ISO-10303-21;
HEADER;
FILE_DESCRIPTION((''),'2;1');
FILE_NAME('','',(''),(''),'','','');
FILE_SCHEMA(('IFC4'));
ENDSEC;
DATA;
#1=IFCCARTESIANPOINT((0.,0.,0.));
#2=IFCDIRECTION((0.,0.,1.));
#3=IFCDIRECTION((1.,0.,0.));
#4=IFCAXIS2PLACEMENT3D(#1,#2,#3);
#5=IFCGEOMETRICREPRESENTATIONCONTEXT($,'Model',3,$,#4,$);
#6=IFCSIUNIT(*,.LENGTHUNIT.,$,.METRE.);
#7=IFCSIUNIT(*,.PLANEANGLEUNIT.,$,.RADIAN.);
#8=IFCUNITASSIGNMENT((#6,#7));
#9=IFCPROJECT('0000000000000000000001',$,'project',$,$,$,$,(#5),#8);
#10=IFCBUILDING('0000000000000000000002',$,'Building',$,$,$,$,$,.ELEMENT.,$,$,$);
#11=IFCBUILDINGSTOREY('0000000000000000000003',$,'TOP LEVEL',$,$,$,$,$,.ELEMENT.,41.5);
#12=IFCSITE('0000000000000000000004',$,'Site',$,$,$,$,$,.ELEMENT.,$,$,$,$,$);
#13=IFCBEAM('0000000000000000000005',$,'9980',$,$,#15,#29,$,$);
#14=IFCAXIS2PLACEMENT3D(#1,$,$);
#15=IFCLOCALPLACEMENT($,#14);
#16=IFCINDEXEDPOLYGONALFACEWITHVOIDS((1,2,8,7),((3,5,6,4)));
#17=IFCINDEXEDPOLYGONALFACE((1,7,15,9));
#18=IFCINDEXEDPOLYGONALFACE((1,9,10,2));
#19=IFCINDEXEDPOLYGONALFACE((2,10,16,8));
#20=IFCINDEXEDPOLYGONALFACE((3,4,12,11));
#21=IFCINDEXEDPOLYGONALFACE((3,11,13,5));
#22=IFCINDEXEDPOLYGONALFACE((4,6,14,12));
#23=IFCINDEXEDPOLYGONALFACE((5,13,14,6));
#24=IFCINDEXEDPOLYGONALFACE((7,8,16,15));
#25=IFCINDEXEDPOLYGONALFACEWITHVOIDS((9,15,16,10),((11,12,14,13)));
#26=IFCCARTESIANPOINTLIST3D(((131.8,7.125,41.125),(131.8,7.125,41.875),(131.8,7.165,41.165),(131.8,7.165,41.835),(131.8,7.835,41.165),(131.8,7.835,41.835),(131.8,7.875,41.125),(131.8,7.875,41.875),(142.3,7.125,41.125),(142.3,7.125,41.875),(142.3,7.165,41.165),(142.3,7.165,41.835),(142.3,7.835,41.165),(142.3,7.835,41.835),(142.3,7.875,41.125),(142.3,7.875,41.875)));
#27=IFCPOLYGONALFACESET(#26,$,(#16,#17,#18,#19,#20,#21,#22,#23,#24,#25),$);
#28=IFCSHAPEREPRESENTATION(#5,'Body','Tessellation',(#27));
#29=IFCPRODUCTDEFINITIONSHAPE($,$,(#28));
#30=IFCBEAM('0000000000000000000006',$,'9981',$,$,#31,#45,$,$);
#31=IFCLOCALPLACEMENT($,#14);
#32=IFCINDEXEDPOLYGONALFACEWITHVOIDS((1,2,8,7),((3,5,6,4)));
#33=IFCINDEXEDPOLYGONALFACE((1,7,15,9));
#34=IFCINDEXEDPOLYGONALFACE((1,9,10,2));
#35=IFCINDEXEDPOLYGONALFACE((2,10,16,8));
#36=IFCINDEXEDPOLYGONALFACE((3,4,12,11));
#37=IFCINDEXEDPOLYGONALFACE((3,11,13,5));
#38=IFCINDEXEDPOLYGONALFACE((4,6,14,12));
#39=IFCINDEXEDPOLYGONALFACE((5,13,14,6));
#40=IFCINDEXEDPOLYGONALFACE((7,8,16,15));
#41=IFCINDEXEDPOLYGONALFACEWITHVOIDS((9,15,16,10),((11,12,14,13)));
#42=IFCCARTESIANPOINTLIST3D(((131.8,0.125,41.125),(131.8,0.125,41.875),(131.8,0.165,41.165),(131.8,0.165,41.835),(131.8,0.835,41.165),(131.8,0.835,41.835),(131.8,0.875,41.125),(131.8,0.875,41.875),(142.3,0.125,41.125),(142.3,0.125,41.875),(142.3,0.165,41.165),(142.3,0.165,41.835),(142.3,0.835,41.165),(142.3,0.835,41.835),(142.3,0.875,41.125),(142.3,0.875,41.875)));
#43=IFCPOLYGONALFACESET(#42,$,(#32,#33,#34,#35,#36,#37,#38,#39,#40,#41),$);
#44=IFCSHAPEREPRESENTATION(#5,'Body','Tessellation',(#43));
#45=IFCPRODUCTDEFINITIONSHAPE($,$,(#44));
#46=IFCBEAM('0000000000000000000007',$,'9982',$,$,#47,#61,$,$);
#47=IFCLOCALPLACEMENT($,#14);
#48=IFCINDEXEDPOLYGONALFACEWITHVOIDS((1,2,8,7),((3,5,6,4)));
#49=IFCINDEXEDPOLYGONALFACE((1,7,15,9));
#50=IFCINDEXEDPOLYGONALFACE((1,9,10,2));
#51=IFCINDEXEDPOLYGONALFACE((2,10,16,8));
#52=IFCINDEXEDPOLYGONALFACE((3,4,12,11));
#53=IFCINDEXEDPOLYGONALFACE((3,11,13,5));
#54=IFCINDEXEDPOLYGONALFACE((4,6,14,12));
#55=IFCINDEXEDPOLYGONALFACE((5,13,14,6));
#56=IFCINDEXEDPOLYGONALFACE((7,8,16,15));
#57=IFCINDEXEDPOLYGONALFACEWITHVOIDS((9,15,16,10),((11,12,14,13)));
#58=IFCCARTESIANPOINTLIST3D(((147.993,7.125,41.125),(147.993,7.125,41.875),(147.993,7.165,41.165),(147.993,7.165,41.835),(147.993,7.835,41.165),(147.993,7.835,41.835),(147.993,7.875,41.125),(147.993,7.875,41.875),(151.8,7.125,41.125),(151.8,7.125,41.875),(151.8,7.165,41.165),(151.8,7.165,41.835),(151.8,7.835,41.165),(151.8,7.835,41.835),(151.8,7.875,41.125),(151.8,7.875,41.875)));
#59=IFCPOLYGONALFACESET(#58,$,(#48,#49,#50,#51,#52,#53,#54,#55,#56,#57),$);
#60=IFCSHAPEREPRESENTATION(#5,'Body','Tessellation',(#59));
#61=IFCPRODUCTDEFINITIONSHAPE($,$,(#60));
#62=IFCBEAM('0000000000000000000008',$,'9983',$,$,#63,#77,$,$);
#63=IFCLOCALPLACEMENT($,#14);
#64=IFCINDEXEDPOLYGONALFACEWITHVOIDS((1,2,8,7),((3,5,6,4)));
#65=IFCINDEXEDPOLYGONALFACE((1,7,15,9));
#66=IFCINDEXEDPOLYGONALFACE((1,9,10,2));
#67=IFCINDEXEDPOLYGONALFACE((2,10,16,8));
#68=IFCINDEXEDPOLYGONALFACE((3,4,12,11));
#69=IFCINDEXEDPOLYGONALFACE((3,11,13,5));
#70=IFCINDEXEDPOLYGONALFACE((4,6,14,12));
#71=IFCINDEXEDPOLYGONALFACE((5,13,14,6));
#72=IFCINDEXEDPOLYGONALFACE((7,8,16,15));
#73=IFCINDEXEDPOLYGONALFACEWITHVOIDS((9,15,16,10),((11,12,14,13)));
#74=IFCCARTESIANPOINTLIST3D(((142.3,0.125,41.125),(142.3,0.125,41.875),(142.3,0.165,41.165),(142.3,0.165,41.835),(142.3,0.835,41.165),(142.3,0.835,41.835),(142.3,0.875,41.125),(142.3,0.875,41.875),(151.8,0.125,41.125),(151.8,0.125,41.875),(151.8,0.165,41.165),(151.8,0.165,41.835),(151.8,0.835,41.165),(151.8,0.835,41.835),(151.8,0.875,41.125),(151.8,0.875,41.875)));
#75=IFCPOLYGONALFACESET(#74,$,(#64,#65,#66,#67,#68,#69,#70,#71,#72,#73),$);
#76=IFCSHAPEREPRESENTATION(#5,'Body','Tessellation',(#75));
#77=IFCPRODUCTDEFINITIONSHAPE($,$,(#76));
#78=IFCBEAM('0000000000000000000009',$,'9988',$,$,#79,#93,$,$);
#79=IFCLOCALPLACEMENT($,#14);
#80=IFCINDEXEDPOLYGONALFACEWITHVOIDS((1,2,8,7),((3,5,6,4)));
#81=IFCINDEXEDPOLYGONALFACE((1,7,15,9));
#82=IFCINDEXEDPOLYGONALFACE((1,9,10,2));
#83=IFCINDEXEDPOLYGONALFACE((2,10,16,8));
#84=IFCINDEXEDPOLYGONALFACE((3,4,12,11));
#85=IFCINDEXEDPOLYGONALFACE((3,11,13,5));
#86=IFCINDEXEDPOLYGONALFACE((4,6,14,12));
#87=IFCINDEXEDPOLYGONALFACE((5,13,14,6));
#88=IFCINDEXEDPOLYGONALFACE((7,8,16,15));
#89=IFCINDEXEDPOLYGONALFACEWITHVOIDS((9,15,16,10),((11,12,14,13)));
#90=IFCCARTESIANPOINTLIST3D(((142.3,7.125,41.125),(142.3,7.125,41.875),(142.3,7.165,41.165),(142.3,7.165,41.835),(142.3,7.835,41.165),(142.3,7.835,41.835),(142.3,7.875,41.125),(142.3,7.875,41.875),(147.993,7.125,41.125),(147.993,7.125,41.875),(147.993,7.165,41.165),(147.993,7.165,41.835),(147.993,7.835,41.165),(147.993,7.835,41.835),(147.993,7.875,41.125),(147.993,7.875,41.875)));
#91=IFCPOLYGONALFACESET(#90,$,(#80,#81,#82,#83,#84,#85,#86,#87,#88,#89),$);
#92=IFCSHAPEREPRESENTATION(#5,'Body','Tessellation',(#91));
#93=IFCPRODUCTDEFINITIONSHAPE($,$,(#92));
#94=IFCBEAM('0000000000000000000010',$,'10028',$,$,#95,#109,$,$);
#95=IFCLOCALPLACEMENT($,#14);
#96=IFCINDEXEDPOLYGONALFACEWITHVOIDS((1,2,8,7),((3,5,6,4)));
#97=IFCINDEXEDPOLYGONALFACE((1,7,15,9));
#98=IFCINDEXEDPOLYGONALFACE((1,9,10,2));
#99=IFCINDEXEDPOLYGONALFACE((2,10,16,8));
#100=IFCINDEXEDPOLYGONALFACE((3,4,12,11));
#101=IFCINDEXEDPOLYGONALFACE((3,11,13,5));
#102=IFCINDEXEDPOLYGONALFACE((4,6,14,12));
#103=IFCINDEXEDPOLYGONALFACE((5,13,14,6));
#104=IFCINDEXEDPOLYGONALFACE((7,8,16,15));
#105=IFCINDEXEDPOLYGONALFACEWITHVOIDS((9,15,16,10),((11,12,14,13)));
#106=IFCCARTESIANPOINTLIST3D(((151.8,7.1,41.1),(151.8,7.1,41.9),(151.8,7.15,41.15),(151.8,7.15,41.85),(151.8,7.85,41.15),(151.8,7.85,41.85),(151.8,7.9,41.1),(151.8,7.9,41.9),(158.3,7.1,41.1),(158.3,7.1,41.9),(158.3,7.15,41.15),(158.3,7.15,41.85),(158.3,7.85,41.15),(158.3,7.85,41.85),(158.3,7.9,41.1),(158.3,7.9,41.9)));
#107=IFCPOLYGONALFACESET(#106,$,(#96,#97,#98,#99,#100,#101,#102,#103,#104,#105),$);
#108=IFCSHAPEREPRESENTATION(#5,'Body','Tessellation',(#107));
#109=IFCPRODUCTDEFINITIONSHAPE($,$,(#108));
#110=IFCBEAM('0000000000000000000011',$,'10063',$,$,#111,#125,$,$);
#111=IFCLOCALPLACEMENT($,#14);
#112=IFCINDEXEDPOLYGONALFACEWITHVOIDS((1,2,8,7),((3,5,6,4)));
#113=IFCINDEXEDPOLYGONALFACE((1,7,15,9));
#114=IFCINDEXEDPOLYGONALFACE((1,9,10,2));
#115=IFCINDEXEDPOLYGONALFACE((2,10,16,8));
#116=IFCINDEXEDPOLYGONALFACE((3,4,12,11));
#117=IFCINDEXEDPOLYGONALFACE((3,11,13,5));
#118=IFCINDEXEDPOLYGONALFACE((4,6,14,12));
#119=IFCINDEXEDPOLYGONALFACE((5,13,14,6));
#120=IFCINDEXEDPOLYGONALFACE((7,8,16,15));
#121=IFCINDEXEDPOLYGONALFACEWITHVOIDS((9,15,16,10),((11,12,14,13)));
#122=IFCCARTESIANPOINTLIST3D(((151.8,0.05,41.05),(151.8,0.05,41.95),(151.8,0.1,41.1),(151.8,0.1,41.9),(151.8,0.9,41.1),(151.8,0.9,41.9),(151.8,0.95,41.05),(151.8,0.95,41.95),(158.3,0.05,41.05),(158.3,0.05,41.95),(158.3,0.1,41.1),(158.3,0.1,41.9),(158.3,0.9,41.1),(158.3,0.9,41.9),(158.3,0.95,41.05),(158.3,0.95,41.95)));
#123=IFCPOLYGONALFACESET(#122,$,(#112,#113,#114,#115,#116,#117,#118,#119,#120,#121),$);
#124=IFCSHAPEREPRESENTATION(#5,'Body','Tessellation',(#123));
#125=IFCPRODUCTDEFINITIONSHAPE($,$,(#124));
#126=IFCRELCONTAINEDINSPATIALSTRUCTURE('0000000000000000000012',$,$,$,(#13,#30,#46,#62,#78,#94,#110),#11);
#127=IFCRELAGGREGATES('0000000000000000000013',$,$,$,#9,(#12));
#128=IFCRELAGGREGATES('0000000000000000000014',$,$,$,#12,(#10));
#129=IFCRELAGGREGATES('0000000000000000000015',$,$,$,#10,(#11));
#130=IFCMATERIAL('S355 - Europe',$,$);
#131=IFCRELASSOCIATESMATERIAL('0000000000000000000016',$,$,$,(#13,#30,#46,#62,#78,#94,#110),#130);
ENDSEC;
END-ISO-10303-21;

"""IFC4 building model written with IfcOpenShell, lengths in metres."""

from ifc_helpers import new_model, si_unit, frame, origin_with_axes, origin_2d_with_axis, place, context, project, spatial, hollow_rectangle, extrude, material, material_profile, profile_set, profile_usage, element, save


model = new_model("IFC4")

# Units and contexts
model_context = context("Model", 3, world=origin_with_axes())
ifc_project = project(units=[si_unit("LENGTHUNIT", "METRE"), si_unit("PLANEANGLEUNIT", "RADIAN")], contexts=[model_context])

# Site, building, storey
site = spatial("IfcSite", under=ifc_project, Name="Site", CompositionType="ELEMENT")
building = spatial("IfcBuilding", under=site, Name="Building", CompositionType="ELEMENT")
storey = spatial("IfcBuildingStorey", under=building, Name="TOP LEVEL", CompositionType="ELEMENT", Elevation=41.5)

# Beams
ifc_material = material(Name="S355 - Europe")
ifc_material_profile_1 = material_profile(ifc_material, hollow_rectangle(XDim=0.75, YDim=0.75, WallThickness=0.04, at=origin_2d_with_axis()))
ifc_profile_set_1 = profile_set([ifc_material_profile_1])
ifc_profile_usage_1 = profile_usage(ifc_profile_set_1, cardinal=10)
beam_1_placement = place(None, frame((142.3, 7.5, 41.5), z_axis=(-1.0, 0.0, 0.0), x_axis=(0.0, -1.0, 0.0)))
element("IfcBeam", 1, at=beam_1_placement, inside=storey, material=ifc_profile_usage_1, Name="9980", context=model_context, shape_type="SweptSolid", body=[
    extrude(hollow_rectangle(XDim=0.75, YDim=0.75, WallThickness=0.04, at=origin_2d_with_axis()), origin_with_axes(), (0.0, 0.0, 1.0), 10.5),
])
ifc_material_profile_2 = material_profile(ifc_material, hollow_rectangle(XDim=0.75, YDim=0.75, WallThickness=0.04, at=origin_2d_with_axis()))
ifc_profile_set_2 = profile_set([ifc_material_profile_2])
ifc_profile_usage_2 = profile_usage(ifc_profile_set_2, cardinal=10)
beam_2_placement = place(None, frame((142.3, 0.5, 41.5), z_axis=(-1.0, 0.0, 0.0), x_axis=(0.0, -1.0, 0.0)))
element("IfcBeam", 2, at=beam_2_placement, inside=storey, material=ifc_profile_usage_2, Name="9981", context=model_context, shape_type="SweptSolid", body=[
    extrude(hollow_rectangle(XDim=0.75, YDim=0.75, WallThickness=0.04, at=origin_2d_with_axis()), origin_with_axes(), (0.0, 0.0, 1.0), 10.5),
])
ifc_material_profile_3 = material_profile(ifc_material, hollow_rectangle(XDim=0.75, YDim=0.75, WallThickness=0.04, at=origin_2d_with_axis()))
ifc_profile_set_3 = profile_set([ifc_material_profile_3])
ifc_profile_usage_3 = profile_usage(ifc_profile_set_3, cardinal=10)
beam_3_placement = place(None, frame((151.8, 7.5, 41.5), z_axis=(-1.0, 0.0, 0.0), x_axis=(0.0, -1.0, 0.0)))
element("IfcBeam", 3, at=beam_3_placement, inside=storey, material=ifc_profile_usage_3, Name="9982", context=model_context, shape_type="SweptSolid", body=[
    extrude(hollow_rectangle(XDim=0.75, YDim=0.75, WallThickness=0.04, at=origin_2d_with_axis()), origin_with_axes(), (0.0, 0.0, 1.0), 3.807),
])
ifc_material_profile_4 = material_profile(ifc_material, hollow_rectangle(XDim=0.75, YDim=0.75, WallThickness=0.04, at=origin_2d_with_axis()))
ifc_profile_set_4 = profile_set([ifc_material_profile_4])
ifc_profile_usage_4 = profile_usage(ifc_profile_set_4, cardinal=10)
beam_4_placement = place(None, frame((151.8, 0.5, 41.5), z_axis=(-1.0, 0.0, 0.0), x_axis=(0.0, -1.0, 0.0)))
element("IfcBeam", 4, at=beam_4_placement, inside=storey, material=ifc_profile_usage_4, Name="9983", context=model_context, shape_type="SweptSolid", body=[
    extrude(hollow_rectangle(XDim=0.75, YDim=0.75, WallThickness=0.04, at=origin_2d_with_axis()), origin_with_axes(), (0.0, 0.0, 1.0), 9.5),
])
ifc_material_profile_5 = material_profile(ifc_material, hollow_rectangle(XDim=0.75, YDim=0.75, WallThickness=0.04, at=origin_2d_with_axis()))
ifc_profile_set_5 = profile_set([ifc_material_profile_5])
ifc_profile_usage_5 = profile_usage(ifc_profile_set_5, cardinal=10)
beam_5_placement = place(None, frame((147.993, 7.5, 41.5), z_axis=(-1.0, 0.0, 0.0), x_axis=(0.0, -1.0, 0.0)))
element("IfcBeam", 5, at=beam_5_placement, inside=storey, material=ifc_profile_usage_5, Name="9988", context=model_context, shape_type="SweptSolid", body=[
    extrude(hollow_rectangle(XDim=0.75, YDim=0.75, WallThickness=0.04, at=origin_2d_with_axis()), origin_with_axes(), (0.0, 0.0, 1.0), 5.693),
])
ifc_material_profile_6 = material_profile(ifc_material, hollow_rectangle(XDim=0.8, YDim=0.8, WallThickness=0.05, at=origin_2d_with_axis()))
ifc_profile_set_6 = profile_set([ifc_material_profile_6])
ifc_profile_usage_6 = profile_usage(ifc_profile_set_6, cardinal=10)
beam_6_placement = place(None, frame((158.3, 7.5, 41.5), z_axis=(-1.0, 0.0, 0.0), x_axis=(0.0, -1.0, 0.0)))
element("IfcBeam", 6, at=beam_6_placement, inside=storey, material=ifc_profile_usage_6, Name="10028", context=model_context, shape_type="SweptSolid", body=[
    extrude(hollow_rectangle(XDim=0.8, YDim=0.8, WallThickness=0.05, at=origin_2d_with_axis()), origin_with_axes(), (0.0, 0.0, 1.0), 6.5),
])
ifc_material_profile_7 = material_profile(ifc_material, hollow_rectangle(XDim=0.9, YDim=0.9, WallThickness=0.05, at=origin_2d_with_axis()))
ifc_profile_set_7 = profile_set([ifc_material_profile_7])
ifc_profile_usage_7 = profile_usage(ifc_profile_set_7, cardinal=10)
beam_7_placement = place(None, frame((151.8, 0.5, 41.5), z_axis=(1.0, 0.0, 0.0), x_axis=(0.0, 1.0, 0.0)))
element("IfcBeam", 7, at=beam_7_placement, inside=storey, material=ifc_profile_usage_7, Name="10063", context=model_context, shape_type="SweptSolid", body=[
    extrude(hollow_rectangle(XDim=0.9, YDim=0.9, WallThickness=0.05, at=origin_2d_with_axis()), origin_with_axes(), (0.0, 0.0, 1.0), 6.5),
])

save(model, "model.ifc")
